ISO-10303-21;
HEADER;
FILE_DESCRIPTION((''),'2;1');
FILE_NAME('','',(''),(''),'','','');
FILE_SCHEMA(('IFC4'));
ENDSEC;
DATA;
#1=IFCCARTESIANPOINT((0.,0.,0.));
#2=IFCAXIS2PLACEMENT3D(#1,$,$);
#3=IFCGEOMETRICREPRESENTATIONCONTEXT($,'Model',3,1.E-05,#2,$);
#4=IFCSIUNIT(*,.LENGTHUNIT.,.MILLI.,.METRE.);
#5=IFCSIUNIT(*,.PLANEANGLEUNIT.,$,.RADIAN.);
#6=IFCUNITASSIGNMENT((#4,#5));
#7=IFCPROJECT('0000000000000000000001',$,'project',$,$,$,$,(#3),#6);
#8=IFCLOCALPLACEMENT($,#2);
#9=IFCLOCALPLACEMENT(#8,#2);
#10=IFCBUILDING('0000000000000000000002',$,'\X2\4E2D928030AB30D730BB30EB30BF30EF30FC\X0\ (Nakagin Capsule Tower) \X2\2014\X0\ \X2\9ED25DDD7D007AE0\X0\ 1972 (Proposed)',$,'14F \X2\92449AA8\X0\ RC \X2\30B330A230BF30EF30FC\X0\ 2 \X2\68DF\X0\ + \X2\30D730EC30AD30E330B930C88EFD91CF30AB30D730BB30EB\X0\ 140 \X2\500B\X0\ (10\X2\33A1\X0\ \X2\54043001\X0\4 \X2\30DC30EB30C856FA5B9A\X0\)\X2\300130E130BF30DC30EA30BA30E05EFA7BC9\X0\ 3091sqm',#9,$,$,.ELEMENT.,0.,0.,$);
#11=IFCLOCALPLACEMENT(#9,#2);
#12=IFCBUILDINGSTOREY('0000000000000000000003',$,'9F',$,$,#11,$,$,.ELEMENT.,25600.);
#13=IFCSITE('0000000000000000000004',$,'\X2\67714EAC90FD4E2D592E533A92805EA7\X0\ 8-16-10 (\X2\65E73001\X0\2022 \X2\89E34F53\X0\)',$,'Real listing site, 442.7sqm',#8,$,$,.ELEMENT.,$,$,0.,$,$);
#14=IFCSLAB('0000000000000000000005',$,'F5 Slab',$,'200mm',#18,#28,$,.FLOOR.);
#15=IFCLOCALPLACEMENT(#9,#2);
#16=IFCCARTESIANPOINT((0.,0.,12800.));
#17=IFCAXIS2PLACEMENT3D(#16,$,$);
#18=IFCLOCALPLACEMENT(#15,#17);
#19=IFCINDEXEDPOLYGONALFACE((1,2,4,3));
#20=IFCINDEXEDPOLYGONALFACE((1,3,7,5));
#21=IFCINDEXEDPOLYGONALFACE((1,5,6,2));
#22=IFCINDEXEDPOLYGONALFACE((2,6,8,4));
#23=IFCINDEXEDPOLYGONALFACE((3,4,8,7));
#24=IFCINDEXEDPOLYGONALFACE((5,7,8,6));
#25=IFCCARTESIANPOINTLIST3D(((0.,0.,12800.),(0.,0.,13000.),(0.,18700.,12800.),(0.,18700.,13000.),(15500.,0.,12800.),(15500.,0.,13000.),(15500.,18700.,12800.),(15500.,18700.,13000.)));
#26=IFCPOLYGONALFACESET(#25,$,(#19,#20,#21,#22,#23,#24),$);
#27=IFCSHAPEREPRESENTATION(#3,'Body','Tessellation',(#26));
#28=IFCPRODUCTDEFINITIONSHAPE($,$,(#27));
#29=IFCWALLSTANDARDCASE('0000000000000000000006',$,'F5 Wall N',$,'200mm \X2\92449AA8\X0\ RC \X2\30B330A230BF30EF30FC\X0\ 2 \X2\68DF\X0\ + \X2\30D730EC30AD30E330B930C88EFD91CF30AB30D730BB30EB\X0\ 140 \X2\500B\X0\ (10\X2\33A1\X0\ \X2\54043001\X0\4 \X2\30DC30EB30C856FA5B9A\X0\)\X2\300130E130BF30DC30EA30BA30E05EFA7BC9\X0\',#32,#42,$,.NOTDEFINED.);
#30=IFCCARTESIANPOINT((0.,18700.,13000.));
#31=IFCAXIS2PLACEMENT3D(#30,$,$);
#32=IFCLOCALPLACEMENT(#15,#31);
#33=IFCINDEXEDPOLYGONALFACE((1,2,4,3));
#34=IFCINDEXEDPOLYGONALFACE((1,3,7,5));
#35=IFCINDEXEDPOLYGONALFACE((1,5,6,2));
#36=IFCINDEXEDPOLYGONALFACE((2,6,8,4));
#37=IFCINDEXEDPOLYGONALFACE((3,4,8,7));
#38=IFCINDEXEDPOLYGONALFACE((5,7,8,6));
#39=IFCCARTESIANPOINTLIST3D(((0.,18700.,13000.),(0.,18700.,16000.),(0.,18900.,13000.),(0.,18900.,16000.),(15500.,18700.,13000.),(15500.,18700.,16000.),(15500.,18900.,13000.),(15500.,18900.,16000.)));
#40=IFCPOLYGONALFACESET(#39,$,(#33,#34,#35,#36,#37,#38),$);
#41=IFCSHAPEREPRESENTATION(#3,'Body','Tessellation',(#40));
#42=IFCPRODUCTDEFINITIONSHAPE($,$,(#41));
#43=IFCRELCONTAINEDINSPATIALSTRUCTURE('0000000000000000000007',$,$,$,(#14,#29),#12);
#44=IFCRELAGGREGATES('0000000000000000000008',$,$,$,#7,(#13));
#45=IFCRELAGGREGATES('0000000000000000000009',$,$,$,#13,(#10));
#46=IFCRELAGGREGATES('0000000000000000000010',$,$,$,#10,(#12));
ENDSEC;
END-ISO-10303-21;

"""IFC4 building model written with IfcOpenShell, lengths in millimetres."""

from ifc_helpers import new_model, si_unit, frame, frame_2d, origin, place, context, project, spatial, rectangle, extrude, element, save


model = new_model("IFC4")

# Units and contexts
model_context = context("Model", 3, precision=1e-05, world=origin())
ifc_project = project(units=[si_unit("LENGTHUNIT", "METRE", prefix="MILLI"), si_unit("PLANEANGLEUNIT", "RADIAN")], contexts=[model_context])

# Site, building, storey
site_placement = place(None, origin())
site = spatial("IfcSite", under=ifc_project, at=site_placement, Name="東京都中央区銀座 8-16-10 (旧、2022 解体)", ObjectType="Real listing site, 442.7sqm", CompositionType="ELEMENT", RefElevation=0.0)
building_placement = place(site_placement, origin())
building = spatial("IfcBuilding", under=site, at=building_placement, Name="中銀カプセルタワー (Nakagin Capsule Tower) — 黒川紀章 1972 (Proposed)", ObjectType="14F 鉄骨 RC コアタワー 2 棟 + プレキャスト軽量カプセル 140 個 (10㎡ 各、4 ボルト固定)、メタボリズム建築 3091sqm", CompositionType="ELEMENT", ElevationOfRefHeight=0.0, ElevationOfTerrain=0.0)
storey_placement = place(building_placement, origin())
storey = spatial("IfcBuildingStorey", under=building, at=storey_placement, Name="9F", CompositionType="ELEMENT", Elevation=25600.0)

# Slab
placement = place(building_placement, origin())
slab_placement = place(placement, frame((0.0, 0.0, 12800.0)))
element("IfcSlab", 1, at=slab_placement, inside=storey, Name="F5 Slab", ObjectType="200mm", PredefinedType="FLOOR", context=model_context, shape_type="SweptSolid", body=[
    extrude(rectangle(XDim=15500.0, YDim=18700.0, at=frame_2d((7750.0, 9350.0))), frame((0.0, 0.0, 12800.0)), (0.0, 0.0, 1.0), 200.0),
])

# Wall
wall_placement = place(placement, frame((0.0, 18700.0, 13000.0)))
element("IfcWallStandardCase", 2, at=wall_placement, inside=storey, Name="F5 Wall N", ObjectType="200mm 鉄骨 RC コアタワー 2 棟 + プレキャスト軽量カプセル 140 個 (10㎡ 各、4 ボルト固定)、メタボリズム建築", PredefinedType="NOTDEFINED", context=model_context, shape_type="SweptSolid", body=[
    extrude(rectangle(XDim=15500.0, YDim=200.0, at=frame_2d((7750.0, 100.0))), frame((0.0, 18700.0, 13000.0)), (0.0, 0.0, 1.0), 3000.0),
])

save(model, "model.ifc")
